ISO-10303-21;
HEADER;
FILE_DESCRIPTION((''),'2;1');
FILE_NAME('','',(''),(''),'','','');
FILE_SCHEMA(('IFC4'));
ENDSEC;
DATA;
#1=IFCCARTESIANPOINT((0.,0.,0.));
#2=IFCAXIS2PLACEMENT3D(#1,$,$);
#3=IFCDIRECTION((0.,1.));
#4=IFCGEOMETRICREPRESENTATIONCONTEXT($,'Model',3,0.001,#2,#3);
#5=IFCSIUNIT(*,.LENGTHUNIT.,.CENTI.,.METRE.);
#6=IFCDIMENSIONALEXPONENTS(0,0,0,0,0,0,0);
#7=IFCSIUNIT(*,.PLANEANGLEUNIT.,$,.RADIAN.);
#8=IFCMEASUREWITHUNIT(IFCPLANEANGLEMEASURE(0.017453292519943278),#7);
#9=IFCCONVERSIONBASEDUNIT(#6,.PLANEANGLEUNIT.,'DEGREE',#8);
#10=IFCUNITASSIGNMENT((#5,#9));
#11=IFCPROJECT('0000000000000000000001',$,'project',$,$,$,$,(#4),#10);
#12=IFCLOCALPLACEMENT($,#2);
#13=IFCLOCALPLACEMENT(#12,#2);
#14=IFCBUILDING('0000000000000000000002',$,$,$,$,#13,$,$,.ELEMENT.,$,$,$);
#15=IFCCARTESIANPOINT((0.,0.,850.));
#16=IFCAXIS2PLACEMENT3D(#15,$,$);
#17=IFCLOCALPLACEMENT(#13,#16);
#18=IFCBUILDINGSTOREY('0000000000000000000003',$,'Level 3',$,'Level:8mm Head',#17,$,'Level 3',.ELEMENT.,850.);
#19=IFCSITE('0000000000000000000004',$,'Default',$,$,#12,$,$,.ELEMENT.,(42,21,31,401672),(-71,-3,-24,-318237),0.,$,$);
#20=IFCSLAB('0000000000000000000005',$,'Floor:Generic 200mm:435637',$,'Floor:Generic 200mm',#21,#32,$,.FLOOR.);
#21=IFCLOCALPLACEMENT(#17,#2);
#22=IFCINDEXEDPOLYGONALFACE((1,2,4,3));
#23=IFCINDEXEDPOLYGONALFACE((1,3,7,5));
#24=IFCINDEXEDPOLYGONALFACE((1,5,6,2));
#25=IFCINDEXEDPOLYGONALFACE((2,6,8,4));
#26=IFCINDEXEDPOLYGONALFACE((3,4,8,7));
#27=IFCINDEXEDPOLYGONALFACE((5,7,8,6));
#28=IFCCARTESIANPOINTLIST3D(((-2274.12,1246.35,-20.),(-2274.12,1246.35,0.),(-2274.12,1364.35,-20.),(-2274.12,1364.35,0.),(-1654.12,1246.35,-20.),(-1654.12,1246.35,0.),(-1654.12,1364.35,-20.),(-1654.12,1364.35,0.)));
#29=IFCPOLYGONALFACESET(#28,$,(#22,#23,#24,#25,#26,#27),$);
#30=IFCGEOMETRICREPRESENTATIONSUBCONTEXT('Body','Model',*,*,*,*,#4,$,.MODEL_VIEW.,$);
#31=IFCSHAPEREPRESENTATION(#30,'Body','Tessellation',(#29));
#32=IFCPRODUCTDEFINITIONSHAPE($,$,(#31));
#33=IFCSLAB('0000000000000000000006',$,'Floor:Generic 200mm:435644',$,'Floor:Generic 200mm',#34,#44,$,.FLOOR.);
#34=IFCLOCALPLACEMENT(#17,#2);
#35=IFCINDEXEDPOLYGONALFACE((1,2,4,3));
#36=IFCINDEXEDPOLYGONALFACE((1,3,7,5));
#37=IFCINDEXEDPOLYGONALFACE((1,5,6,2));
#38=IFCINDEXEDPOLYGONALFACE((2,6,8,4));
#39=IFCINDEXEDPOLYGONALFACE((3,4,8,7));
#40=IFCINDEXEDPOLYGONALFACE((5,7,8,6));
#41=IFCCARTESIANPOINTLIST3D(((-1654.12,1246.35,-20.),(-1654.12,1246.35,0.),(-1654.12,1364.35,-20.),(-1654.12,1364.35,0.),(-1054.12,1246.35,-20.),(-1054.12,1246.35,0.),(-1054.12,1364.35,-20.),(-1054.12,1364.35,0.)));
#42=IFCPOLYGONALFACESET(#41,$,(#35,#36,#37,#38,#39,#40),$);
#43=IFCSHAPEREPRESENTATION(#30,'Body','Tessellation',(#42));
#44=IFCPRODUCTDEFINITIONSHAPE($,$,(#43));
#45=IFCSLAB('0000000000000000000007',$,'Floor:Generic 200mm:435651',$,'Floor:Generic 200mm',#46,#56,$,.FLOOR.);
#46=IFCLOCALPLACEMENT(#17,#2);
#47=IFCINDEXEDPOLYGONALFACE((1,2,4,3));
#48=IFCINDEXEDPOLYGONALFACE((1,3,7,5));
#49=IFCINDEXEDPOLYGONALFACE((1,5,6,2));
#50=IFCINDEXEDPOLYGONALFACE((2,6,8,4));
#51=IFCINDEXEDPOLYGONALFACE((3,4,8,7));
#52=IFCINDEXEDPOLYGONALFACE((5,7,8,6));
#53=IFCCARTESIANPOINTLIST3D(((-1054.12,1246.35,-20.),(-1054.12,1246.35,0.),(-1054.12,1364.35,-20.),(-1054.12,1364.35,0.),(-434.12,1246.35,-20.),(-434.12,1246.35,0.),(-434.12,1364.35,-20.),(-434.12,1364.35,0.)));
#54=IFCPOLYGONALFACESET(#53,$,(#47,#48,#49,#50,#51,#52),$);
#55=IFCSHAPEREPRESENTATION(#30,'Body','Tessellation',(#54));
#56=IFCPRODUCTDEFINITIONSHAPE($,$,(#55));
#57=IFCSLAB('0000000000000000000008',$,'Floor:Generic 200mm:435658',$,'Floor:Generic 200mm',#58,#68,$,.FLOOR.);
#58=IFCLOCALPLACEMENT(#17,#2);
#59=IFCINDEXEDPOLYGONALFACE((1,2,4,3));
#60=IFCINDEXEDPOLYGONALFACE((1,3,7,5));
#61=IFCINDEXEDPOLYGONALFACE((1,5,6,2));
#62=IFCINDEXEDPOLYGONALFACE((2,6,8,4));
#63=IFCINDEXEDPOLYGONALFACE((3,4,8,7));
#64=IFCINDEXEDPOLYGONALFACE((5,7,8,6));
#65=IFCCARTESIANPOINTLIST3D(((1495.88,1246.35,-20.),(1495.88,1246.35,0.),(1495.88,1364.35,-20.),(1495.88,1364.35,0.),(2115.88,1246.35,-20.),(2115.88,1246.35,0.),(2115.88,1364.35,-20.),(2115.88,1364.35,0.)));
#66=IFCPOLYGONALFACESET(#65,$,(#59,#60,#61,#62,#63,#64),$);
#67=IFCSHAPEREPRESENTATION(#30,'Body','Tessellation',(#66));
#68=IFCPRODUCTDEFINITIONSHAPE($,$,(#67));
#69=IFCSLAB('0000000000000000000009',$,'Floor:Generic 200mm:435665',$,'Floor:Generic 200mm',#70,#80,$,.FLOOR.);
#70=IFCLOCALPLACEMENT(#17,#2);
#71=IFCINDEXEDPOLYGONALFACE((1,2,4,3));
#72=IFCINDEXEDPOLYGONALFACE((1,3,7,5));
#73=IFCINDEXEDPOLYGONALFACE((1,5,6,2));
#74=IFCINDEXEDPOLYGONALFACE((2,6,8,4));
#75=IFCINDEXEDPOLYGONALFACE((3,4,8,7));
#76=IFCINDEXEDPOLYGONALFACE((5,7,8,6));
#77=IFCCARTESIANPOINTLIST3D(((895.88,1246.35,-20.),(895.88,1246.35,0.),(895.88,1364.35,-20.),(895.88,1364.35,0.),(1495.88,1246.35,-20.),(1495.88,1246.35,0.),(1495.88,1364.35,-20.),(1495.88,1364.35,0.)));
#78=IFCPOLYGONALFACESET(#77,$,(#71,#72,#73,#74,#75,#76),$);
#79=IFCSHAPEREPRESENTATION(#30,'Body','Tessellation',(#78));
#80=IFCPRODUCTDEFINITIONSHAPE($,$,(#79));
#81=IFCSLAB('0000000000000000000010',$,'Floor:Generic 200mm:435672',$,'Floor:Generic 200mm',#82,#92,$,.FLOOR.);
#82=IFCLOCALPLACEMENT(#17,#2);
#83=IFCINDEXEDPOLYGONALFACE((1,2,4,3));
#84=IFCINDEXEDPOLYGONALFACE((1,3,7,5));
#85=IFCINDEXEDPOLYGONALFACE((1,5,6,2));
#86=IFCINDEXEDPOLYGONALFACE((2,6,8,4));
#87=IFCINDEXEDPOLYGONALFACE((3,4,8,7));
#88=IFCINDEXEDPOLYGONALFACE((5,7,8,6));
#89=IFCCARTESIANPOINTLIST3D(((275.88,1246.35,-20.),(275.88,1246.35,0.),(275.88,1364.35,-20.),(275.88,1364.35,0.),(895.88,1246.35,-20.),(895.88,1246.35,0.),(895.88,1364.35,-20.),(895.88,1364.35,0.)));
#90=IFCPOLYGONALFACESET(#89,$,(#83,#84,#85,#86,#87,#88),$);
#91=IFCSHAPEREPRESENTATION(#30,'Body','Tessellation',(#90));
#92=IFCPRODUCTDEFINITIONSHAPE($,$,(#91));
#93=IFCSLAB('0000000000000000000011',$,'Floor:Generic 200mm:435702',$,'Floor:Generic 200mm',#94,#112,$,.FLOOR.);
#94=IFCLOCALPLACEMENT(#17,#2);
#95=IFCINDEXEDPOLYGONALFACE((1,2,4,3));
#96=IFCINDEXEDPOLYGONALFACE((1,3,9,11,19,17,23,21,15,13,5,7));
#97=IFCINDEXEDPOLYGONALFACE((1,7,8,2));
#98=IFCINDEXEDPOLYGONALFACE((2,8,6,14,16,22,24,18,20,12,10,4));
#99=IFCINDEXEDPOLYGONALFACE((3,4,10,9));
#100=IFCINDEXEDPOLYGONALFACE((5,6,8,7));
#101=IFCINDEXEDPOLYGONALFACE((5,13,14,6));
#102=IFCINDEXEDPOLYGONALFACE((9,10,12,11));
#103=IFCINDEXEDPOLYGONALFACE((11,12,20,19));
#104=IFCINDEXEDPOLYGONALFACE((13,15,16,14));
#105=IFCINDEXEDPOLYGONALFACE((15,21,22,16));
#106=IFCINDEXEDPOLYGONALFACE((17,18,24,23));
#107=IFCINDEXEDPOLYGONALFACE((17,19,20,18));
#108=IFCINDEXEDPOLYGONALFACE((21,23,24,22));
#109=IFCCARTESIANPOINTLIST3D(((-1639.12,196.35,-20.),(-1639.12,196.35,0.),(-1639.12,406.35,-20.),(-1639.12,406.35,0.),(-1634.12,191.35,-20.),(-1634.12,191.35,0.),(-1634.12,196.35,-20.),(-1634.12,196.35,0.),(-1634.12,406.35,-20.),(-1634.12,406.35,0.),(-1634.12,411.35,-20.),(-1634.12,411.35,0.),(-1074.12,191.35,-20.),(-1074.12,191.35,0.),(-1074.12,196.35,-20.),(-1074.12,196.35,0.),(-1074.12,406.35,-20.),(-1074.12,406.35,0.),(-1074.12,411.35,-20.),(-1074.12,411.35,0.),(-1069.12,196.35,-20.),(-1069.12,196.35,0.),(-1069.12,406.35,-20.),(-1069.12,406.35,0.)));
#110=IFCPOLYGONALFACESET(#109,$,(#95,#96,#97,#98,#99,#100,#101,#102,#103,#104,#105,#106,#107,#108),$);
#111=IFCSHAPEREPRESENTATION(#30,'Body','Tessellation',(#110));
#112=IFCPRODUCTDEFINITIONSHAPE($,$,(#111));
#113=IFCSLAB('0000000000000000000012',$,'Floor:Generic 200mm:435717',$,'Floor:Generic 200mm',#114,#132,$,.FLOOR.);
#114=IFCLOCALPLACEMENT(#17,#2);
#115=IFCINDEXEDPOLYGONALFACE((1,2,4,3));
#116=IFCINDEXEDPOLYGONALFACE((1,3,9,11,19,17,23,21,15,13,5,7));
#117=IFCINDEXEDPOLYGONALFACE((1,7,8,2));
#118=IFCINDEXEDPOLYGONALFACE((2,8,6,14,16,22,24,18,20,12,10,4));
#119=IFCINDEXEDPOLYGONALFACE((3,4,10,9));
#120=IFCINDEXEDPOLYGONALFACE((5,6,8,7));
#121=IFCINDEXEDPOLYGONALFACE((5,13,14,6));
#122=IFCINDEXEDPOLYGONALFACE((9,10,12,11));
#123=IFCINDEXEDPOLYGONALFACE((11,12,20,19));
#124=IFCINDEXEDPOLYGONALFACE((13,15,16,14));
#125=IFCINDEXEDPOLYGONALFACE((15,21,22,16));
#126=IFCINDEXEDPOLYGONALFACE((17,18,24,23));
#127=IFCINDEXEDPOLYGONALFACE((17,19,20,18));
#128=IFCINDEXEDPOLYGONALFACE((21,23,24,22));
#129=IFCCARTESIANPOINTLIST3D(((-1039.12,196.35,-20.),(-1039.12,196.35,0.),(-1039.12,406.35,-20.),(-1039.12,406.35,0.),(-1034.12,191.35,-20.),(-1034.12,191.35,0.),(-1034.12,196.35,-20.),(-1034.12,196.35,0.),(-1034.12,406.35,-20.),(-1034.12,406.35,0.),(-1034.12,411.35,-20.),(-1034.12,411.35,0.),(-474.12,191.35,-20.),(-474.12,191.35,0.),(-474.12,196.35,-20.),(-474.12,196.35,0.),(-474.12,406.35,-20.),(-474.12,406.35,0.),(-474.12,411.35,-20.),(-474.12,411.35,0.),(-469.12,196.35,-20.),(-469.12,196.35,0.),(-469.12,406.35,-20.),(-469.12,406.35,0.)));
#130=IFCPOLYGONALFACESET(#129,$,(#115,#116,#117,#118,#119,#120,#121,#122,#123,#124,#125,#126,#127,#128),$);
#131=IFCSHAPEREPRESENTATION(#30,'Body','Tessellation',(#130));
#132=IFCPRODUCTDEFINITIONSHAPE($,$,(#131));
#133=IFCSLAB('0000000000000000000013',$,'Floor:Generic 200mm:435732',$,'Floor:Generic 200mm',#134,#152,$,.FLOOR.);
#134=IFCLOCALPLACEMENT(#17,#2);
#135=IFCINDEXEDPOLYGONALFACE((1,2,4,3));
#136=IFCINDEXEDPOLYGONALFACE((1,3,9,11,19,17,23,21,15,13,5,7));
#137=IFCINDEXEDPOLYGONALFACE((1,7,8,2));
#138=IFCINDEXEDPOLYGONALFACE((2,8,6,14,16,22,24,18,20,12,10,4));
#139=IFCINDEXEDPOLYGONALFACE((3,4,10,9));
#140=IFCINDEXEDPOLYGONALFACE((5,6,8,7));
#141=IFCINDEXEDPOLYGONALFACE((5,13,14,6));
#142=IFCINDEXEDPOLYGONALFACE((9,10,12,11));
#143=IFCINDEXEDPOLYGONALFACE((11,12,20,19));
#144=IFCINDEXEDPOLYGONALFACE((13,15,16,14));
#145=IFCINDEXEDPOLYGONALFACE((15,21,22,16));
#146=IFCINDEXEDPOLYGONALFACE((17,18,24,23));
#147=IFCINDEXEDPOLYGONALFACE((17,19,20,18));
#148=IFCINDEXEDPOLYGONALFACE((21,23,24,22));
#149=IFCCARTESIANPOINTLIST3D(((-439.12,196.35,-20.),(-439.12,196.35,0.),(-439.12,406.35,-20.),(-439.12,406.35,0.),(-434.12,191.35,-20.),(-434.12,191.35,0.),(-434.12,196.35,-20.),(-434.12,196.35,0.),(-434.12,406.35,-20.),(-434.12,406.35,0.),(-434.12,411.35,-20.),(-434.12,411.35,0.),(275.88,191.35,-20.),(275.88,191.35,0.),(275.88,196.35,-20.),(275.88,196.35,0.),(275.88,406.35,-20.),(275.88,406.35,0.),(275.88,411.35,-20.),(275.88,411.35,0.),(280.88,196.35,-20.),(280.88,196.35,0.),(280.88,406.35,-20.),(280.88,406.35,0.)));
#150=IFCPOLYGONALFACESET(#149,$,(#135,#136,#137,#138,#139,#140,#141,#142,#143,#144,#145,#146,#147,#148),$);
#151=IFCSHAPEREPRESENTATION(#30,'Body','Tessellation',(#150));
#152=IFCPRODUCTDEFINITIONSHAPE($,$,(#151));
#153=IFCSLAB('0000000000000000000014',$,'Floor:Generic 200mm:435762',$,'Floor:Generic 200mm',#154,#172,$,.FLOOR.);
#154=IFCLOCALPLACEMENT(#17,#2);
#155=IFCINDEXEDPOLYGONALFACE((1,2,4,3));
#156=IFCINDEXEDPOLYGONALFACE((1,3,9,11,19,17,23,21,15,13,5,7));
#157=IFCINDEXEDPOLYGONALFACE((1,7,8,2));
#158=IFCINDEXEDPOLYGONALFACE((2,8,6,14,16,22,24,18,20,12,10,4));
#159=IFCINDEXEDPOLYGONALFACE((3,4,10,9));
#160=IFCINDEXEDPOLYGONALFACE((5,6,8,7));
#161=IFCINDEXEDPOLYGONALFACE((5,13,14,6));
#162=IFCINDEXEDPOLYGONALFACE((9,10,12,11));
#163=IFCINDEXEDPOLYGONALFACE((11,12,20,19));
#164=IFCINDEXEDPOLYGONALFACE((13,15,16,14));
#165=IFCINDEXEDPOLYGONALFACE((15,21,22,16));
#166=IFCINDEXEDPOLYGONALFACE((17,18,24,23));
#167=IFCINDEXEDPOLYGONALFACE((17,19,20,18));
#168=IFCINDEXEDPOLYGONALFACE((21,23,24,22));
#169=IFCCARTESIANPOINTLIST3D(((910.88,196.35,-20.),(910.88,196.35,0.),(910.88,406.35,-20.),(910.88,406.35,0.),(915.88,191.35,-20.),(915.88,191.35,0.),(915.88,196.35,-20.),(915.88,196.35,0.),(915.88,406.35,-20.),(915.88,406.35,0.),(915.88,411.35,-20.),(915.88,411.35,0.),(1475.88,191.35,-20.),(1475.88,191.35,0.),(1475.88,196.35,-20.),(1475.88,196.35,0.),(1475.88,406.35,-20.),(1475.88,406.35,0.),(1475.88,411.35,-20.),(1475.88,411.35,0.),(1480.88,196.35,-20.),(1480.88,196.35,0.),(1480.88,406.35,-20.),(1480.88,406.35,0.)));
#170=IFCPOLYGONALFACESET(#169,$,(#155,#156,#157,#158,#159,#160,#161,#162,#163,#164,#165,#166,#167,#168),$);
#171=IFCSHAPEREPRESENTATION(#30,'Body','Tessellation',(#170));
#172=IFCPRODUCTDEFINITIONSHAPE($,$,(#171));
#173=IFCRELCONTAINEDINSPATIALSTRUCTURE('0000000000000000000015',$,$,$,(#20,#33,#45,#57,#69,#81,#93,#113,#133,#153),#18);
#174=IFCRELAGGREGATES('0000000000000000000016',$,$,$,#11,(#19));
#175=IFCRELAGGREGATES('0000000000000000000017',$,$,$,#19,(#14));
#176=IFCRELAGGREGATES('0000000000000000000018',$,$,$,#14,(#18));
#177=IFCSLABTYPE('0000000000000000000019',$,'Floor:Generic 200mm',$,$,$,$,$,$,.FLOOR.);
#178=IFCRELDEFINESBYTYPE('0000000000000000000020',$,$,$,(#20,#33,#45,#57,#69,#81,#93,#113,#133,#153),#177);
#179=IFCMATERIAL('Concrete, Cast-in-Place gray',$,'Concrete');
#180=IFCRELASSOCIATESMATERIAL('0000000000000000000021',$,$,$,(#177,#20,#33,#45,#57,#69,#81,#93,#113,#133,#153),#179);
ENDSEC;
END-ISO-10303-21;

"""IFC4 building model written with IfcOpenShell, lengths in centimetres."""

from ifc_helpers import new_model, entity, si_unit, converted_unit, direction, frame, origin, place, context, subcontext, project, spatial, indexed_curve, outline, extrude, material, type_object, element, save


model = new_model("IFC4")

# Units and contexts
model_context = context("Model", 3, precision=0.001, world=origin(), true_north=direction((0.0, 1.0)))
body_context = subcontext(model_context, "Body", "Model", "MODEL_VIEW")
ifc_project = project(units=[si_unit("LENGTHUNIT", "METRE", prefix="CENTI"), converted_unit("PLANEANGLEUNIT", "DEGREE", entity("IfcPlaneAngleMeasure", 0.017453292519943278), si_unit("PLANEANGLEUNIT", "RADIAN"), dimensions=[0, 0, 0, 0, 0, 0, 0])], contexts=[model_context])

# Site, building, storey
site_placement = place(None, origin())
site = spatial("IfcSite", under=ifc_project, at=site_placement, Name="Default", CompositionType="ELEMENT", RefLatitude=(42, 21, 31, 401672), RefLongitude=(-71, -3, -24, -318237), RefElevation=0.0)
building_placement = place(site_placement, origin())
building = spatial("IfcBuilding", under=site, at=building_placement, CompositionType="ELEMENT")
storey_placement = place(building_placement, frame((0.0, 0.0, 850.0)))
storey = spatial("IfcBuildingStorey", under=building, at=storey_placement, Name="Level 3", ObjectType="Level:8mm Head", LongName="Level 3", CompositionType="ELEMENT", Elevation=850.0)

# Shared definitions
ifc_material = material(Name="Concrete, Cast-in-Place gray", Category="Concrete")
slab_type = type_object("IfcSlabType", Name="Floor:Generic 200mm", PredefinedType="FLOOR", material=ifc_material)

# Slabs
slab_1_placement = place(storey_placement, origin())
element("IfcSlab", 1, at=slab_1_placement, inside=storey, type_object=slab_type, material=ifc_material, Name="Floor:Generic 200mm:435637", ObjectType="Floor:Generic 200mm", PredefinedType="FLOOR", context=body_context, shape_type="SweptSolid", body=[
    extrude(outline(indexed_curve([(-59.0, -310.0), (59.0, -310.0), (59.0, 310.0), (-59.0, 310.0), (-59.0, -310.0)], self_intersect=False)), frame((-1964.12, 1305.35, 0.0), z_axis=(0.0, 0.0, -1.0), x_axis=(0.0, 1.0, 0.0)), (0.0, 0.0, 1.0), 20.0),
])
slab_2_placement = place(storey_placement, origin())
element("IfcSlab", 2, at=slab_2_placement, inside=storey, type_object=slab_type, material=ifc_material, Name="Floor:Generic 200mm:435644", ObjectType="Floor:Generic 200mm", PredefinedType="FLOOR", context=body_context, shape_type="SweptSolid", body=[
    extrude(outline(indexed_curve([(-59.0, -300.0), (59.0, -300.0), (59.0, 300.0), (-59.0, 300.0), (-59.0, -300.0)], self_intersect=False)), frame((-1354.12, 1305.35, 0.0), z_axis=(0.0, 0.0, -1.0), x_axis=(0.0, 1.0, 0.0)), (0.0, 0.0, 1.0), 20.0),
])
slab_3_placement = place(storey_placement, origin())
element("IfcSlab", 3, at=slab_3_placement, inside=storey, type_object=slab_type, material=ifc_material, Name="Floor:Generic 200mm:435651", ObjectType="Floor:Generic 200mm", PredefinedType="FLOOR", context=body_context, shape_type="SweptSolid", body=[
    extrude(outline(indexed_curve([(-59.0, -310.0), (59.0, -310.0), (59.0, 310.0), (-59.0, 310.0), (-59.0, -310.0)], self_intersect=False)), frame((-744.12, 1305.35, 0.0), z_axis=(0.0, 0.0, -1.0), x_axis=(0.0, 1.0, 0.0)), (0.0, 0.0, 1.0), 20.0),
])
slab_4_placement = place(storey_placement, origin())
element("IfcSlab", 4, at=slab_4_placement, inside=storey, type_object=slab_type, material=ifc_material, Name="Floor:Generic 200mm:435658", ObjectType="Floor:Generic 200mm", PredefinedType="FLOOR", context=body_context, shape_type="SweptSolid", body=[
    extrude(outline(indexed_curve([(-59.0, -310.0), (59.0, -310.0), (59.0, 310.0), (-59.0, 310.0), (-59.0, -310.0)], self_intersect=False)), frame((1805.88, 1305.35, 0.0), z_axis=(0.0, 0.0, -1.0), x_axis=(0.0, 1.0, 0.0)), (0.0, 0.0, 1.0), 20.0),
])
slab_5_placement = place(storey_placement, origin())
element("IfcSlab", 5, at=slab_5_placement, inside=storey, type_object=slab_type, material=ifc_material, Name="Floor:Generic 200mm:435665", ObjectType="Floor:Generic 200mm", PredefinedType="FLOOR", context=body_context, shape_type="SweptSolid", body=[
    extrude(outline(indexed_curve([(-59.0, -300.0), (59.0, -300.0), (59.0, 300.0), (-59.0, 300.0), (-59.0, -300.0)], self_intersect=False)), frame((1195.88, 1305.35, 0.0), z_axis=(0.0, 0.0, -1.0), x_axis=(0.0, 1.0, 0.0)), (0.0, 0.0, 1.0), 20.0),
])
slab_6_placement = place(storey_placement, origin())
element("IfcSlab", 6, at=slab_6_placement, inside=storey, type_object=slab_type, material=ifc_material, Name="Floor:Generic 200mm:435672", ObjectType="Floor:Generic 200mm", PredefinedType="FLOOR", context=body_context, shape_type="SweptSolid", body=[
    extrude(outline(indexed_curve([(-59.0, -310.0), (59.0, -310.0), (59.0, 310.0), (-59.0, 310.0), (-59.0, -310.0)], self_intersect=False)), frame((585.88, 1305.35, 0.0), z_axis=(0.0, 0.0, -1.0), x_axis=(0.0, 1.0, 0.0)), (0.0, 0.0, 1.0), 20.0),
])
slab_7_placement = place(storey_placement, origin())
element("IfcSlab", 7, at=slab_7_placement, inside=storey, type_object=slab_type, material=ifc_material, Name="Floor:Generic 200mm:435702", ObjectType="Floor:Generic 200mm", PredefinedType="FLOOR", context=body_context, shape_type="SweptSolid", body=[
    extrude(outline(indexed_curve([(-105.0, -285.0), (105.0, -285.0), (105.0, -280.0), (110.0, -280.0), (110.0, 280.0), (105.0, 280.0), (105.0, 285.0), (-105.0, 285.0), (-105.0, 280.0), (-110.0, 280.0), (-110.0, -280.0), (-105.0, -280.0), (-105.0, -285.0)], self_intersect=False)), frame((-1354.12, 301.35, 0.0), z_axis=(0.0, 0.0, -1.0), x_axis=(0.0, 1.0, 0.0)), (0.0, 0.0, 1.0), 20.0),
])
slab_8_placement = place(storey_placement, origin())
element("IfcSlab", 8, at=slab_8_placement, inside=storey, type_object=slab_type, material=ifc_material, Name="Floor:Generic 200mm:435717", ObjectType="Floor:Generic 200mm", PredefinedType="FLOOR", context=body_context, shape_type="SweptSolid", body=[
    extrude(outline(indexed_curve([(-105.0, -285.0), (105.0, -285.0), (105.0, -280.0), (110.0, -280.0), (110.0, 280.0), (105.0, 280.0), (105.0, 285.0), (-105.0, 285.0), (-105.0, 280.0), (-110.0, 280.0), (-110.0, -280.0), (-105.0, -280.0), (-105.0, -285.0)], self_intersect=False)), frame((-754.12, 301.35, 0.0), z_axis=(0.0, 0.0, -1.0), x_axis=(0.0, 1.0, 0.0)), (0.0, 0.0, 1.0), 20.0),
])
slab_9_placement = place(storey_placement, origin())
element("IfcSlab", 9, at=slab_9_placement, inside=storey, type_object=slab_type, material=ifc_material, Name="Floor:Generic 200mm:435732", ObjectType="Floor:Generic 200mm", PredefinedType="FLOOR", context=body_context, shape_type="SweptSolid", body=[
    extrude(outline(indexed_curve([(-105.0, -360.0), (105.0, -360.0), (105.0, -355.0), (110.0, -355.0), (110.0, 355.0), (105.0, 355.0), (105.0, 360.0), (-105.0, 360.0), (-105.0, 355.0), (-110.0, 355.0), (-110.0, -355.0), (-105.0, -355.0), (-105.0, -360.0)], self_intersect=False)), frame((-79.12, 301.35, 0.0), z_axis=(0.0, 0.0, -1.0), x_axis=(0.0, 1.0, 0.0)), (0.0, 0.0, 1.0), 20.0),
])
slab_10_placement = place(storey_placement, origin())
element("IfcSlab", 10, at=slab_10_placement, inside=storey, type_object=slab_type, material=ifc_material, Name="Floor:Generic 200mm:435762", ObjectType="Floor:Generic 200mm", PredefinedType="FLOOR", context=body_context, shape_type="SweptSolid", body=[
    extrude(outline(indexed_curve([(-105.0, -285.0), (105.0, -285.0), (105.0, -280.0), (110.0, -280.0), (110.0, 280.0), (105.0, 280.0), (105.0, 285.0), (-105.0, 285.0), (-105.0, 280.0), (-110.0, 280.0), (-110.0, -280.0), (-105.0, -280.0), (-105.0, -285.0)], self_intersect=False)), frame((1195.88, 301.35, 0.0), z_axis=(0.0, 0.0, -1.0), x_axis=(0.0, 1.0, 0.0)), (0.0, 0.0, 1.0), 20.0),
])

save(model, "model.ifc")
